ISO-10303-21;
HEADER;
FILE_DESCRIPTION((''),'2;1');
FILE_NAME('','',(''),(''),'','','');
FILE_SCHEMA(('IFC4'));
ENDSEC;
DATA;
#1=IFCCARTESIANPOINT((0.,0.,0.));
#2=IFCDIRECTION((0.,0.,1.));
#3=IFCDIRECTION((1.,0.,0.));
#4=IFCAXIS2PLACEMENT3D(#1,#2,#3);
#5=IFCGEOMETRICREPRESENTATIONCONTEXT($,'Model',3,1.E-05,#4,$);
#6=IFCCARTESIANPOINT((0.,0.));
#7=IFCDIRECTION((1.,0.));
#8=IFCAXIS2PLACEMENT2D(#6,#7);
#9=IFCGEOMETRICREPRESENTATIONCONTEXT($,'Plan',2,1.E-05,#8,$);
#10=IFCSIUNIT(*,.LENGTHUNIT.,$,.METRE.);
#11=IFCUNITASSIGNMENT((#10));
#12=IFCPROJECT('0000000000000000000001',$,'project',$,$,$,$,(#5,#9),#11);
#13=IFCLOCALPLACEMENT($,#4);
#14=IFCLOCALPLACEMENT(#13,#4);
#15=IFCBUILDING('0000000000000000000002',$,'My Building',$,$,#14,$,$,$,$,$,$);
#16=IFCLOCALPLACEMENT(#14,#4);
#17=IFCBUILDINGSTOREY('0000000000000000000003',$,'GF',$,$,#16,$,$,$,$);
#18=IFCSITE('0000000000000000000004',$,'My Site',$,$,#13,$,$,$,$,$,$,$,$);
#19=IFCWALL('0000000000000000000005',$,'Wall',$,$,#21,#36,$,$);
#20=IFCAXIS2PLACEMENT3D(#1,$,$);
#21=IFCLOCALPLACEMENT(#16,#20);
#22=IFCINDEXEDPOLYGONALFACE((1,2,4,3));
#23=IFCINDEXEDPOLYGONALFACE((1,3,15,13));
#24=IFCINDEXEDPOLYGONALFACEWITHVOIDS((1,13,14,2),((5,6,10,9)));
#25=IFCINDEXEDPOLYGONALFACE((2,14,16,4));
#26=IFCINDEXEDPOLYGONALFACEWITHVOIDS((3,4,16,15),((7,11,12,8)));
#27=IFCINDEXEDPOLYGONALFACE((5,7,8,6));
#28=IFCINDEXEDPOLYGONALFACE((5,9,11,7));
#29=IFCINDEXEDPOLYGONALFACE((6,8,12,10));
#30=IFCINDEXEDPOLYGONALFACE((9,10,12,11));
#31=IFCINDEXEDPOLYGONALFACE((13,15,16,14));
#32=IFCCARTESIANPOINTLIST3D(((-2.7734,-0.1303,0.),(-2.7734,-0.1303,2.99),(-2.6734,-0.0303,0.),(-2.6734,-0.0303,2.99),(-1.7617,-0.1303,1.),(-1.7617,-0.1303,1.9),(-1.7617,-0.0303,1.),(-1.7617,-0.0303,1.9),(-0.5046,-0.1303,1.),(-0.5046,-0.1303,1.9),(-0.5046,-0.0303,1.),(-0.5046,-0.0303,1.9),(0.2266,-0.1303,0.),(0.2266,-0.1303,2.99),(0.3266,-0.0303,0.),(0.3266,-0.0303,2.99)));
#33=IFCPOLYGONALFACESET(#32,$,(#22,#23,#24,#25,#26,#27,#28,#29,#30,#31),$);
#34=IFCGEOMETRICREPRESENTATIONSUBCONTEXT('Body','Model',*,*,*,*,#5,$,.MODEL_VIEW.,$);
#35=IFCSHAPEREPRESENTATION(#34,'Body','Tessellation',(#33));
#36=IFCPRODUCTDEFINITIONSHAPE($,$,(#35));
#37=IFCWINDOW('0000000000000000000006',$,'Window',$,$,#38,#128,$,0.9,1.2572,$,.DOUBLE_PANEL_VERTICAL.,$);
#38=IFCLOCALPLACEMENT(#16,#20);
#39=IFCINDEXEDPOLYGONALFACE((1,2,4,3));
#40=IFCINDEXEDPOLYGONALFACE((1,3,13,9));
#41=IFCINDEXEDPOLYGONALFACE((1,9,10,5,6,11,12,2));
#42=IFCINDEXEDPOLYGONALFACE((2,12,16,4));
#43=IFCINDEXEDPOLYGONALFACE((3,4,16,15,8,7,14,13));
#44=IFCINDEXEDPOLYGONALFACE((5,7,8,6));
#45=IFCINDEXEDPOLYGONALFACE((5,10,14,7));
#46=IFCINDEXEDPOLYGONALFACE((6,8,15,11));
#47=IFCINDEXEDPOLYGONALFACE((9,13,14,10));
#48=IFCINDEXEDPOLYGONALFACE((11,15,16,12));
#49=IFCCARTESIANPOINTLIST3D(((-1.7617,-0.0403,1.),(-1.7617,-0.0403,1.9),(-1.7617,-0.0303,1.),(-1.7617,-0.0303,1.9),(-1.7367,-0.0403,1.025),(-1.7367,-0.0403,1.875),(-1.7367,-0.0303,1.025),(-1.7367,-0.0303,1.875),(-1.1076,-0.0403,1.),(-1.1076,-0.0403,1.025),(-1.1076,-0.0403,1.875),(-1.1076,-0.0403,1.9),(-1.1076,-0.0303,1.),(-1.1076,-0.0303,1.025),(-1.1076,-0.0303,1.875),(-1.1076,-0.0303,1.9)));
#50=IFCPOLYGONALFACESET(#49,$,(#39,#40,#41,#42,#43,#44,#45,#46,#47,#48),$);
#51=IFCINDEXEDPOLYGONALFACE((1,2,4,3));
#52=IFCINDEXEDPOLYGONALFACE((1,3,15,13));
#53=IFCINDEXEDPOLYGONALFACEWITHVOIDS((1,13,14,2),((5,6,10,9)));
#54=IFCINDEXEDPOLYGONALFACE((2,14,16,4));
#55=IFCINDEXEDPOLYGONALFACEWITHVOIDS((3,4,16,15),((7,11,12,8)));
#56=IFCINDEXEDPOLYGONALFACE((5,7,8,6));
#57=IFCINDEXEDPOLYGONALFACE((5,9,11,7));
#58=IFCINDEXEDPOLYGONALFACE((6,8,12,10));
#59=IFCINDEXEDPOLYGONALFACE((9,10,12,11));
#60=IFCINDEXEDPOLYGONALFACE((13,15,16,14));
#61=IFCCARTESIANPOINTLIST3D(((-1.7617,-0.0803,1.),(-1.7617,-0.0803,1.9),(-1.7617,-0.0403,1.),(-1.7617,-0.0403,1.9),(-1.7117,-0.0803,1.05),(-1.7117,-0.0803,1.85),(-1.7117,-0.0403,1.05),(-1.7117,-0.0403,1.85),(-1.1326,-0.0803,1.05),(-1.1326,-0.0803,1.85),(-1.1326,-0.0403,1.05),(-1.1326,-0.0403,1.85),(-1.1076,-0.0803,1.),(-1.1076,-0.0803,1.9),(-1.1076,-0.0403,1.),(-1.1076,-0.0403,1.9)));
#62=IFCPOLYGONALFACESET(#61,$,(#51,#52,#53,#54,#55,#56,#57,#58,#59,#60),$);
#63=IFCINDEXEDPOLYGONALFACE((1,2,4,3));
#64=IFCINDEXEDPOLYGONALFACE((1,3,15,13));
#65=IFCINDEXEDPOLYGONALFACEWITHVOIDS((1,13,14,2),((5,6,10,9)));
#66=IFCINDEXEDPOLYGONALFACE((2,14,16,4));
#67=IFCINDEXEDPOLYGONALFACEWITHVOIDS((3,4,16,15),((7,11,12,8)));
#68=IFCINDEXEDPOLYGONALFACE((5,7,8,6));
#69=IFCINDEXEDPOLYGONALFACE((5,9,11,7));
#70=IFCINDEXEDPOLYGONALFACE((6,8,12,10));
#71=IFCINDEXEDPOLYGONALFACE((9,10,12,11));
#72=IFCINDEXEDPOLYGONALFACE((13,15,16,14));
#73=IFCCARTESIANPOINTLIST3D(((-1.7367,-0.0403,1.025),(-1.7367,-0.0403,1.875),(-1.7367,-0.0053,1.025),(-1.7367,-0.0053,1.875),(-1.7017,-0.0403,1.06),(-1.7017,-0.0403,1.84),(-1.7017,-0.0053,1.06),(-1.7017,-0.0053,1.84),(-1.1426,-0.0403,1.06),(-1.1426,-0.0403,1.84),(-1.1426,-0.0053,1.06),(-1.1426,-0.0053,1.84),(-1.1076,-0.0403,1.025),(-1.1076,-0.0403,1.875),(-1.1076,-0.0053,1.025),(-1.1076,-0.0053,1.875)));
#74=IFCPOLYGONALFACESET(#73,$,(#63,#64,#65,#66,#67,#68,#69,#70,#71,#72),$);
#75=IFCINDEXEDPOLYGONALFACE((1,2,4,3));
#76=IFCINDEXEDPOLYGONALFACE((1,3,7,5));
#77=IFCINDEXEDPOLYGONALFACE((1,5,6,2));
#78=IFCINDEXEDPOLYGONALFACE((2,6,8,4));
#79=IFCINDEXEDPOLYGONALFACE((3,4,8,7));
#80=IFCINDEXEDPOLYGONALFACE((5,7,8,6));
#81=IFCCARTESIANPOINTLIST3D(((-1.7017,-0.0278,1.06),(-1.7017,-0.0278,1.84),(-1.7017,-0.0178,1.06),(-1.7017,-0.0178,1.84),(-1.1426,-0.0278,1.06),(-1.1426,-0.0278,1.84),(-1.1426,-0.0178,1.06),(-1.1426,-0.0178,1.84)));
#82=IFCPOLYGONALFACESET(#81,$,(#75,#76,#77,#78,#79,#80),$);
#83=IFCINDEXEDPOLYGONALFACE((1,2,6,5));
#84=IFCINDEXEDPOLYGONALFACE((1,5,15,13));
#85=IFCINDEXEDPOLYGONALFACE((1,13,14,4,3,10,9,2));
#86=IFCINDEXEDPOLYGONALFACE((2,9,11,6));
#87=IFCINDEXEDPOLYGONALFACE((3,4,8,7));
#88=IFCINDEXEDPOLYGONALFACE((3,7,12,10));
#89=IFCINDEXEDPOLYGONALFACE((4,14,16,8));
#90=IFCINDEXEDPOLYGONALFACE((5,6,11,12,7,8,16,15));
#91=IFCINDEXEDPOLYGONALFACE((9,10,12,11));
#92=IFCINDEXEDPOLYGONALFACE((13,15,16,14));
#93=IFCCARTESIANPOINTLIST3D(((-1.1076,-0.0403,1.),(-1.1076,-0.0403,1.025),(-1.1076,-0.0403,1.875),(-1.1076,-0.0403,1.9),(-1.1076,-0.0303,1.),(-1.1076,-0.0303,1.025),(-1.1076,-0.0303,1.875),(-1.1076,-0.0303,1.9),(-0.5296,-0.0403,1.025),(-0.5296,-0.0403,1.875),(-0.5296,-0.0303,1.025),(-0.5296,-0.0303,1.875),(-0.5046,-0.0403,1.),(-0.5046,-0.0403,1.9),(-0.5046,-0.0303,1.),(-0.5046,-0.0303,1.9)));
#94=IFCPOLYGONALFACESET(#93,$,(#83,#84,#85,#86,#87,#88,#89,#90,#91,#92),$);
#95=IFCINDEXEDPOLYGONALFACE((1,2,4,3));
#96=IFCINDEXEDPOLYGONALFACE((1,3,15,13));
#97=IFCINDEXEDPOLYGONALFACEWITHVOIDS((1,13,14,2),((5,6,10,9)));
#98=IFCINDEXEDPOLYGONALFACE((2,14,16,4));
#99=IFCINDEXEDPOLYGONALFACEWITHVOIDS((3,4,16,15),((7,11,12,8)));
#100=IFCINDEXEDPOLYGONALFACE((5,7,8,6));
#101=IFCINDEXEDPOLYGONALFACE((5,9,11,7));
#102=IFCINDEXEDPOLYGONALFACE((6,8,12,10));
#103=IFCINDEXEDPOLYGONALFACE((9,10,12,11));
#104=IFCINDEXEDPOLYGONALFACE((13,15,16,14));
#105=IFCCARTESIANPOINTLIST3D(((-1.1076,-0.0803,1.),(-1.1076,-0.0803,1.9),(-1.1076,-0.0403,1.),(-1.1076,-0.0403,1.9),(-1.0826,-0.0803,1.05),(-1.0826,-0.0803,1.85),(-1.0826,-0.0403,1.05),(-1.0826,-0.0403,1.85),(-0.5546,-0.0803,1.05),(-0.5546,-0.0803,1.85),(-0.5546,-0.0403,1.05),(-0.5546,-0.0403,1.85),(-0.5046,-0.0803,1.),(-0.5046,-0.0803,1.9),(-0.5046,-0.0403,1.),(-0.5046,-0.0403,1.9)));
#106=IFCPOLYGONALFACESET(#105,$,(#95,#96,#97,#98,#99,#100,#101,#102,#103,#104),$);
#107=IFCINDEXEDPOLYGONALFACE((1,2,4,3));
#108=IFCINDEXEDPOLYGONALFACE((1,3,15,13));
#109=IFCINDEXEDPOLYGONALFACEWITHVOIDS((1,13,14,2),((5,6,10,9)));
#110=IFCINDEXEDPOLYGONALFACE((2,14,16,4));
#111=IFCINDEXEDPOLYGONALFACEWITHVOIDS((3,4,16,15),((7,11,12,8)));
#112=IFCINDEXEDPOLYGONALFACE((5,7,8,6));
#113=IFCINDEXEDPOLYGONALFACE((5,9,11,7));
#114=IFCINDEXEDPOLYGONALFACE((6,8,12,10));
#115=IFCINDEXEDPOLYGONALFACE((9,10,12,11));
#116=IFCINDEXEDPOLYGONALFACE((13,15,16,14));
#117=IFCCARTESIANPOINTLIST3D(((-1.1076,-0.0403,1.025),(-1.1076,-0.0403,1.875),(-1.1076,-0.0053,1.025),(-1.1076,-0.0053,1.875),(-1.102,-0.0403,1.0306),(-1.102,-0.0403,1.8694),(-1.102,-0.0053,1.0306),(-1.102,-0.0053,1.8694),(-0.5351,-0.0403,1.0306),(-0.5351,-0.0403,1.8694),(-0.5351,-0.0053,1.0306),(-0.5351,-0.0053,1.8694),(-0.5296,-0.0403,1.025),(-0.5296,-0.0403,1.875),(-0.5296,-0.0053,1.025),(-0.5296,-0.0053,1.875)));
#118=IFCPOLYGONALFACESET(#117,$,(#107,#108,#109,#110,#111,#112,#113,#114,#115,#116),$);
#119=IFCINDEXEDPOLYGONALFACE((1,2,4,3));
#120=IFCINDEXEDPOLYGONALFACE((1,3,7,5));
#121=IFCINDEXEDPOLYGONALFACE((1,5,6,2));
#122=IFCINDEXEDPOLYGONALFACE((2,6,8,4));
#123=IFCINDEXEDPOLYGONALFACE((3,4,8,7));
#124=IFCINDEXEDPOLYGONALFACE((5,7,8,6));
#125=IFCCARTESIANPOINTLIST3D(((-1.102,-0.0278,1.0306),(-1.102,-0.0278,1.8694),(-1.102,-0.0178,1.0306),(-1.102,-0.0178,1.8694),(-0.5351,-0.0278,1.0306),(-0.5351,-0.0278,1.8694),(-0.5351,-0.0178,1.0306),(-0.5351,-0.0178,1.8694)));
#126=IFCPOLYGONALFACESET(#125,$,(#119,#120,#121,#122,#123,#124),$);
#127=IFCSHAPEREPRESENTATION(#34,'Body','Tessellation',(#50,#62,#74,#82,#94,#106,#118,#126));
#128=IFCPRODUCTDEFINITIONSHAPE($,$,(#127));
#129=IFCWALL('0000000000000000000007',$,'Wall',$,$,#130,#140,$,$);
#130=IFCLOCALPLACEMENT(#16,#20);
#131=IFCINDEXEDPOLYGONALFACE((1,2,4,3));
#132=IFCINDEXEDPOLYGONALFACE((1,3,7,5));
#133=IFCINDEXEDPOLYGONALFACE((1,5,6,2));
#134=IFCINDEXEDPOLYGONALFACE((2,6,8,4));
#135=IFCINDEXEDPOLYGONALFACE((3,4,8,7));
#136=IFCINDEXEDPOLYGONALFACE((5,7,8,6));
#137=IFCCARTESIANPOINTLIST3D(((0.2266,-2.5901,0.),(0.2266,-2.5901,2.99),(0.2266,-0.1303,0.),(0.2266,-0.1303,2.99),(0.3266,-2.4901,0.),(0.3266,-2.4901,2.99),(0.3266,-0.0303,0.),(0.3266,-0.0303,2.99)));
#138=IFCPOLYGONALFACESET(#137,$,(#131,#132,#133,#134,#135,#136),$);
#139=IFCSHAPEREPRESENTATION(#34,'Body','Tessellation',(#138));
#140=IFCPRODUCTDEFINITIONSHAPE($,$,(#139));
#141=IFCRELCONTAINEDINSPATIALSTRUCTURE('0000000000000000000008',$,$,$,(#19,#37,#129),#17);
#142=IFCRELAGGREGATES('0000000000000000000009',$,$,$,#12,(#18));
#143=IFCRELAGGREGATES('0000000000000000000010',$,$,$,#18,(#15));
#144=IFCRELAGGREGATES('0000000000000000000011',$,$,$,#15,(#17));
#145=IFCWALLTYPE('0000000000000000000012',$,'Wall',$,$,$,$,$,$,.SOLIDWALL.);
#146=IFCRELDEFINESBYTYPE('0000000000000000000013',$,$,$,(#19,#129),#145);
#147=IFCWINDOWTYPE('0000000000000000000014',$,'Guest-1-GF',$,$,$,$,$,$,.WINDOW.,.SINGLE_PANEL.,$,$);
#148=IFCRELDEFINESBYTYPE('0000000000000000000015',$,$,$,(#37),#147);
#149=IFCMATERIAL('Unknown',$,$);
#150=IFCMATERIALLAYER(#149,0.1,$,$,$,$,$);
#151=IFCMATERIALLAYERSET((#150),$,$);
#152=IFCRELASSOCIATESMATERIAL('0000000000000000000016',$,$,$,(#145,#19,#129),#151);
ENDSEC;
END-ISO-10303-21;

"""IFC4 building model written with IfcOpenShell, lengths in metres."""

from ifc_helpers import new_model, entity, si_unit, frame, origin_with_axes, origin_2d_with_axis, place, context, subcontext, project, spatial, line, indexed_curve, outline, extrude, shape, source, transform, mapped, material, layer, layer_set, layer_usage, type_object, type_shapes, element, fill, save


model = new_model("IFC4")

# Units and contexts
model_context = context("Model", 3, precision=1e-05, world=origin_with_axes())
plan_context = context("Plan", 2, precision=1e-05, world=origin_2d_with_axis())
body_context_1 = subcontext(model_context, "Body", "Model", "MODEL_VIEW")
body_context_2 = subcontext(plan_context, "Body", "Plan", "PLAN_VIEW")
ifc_project = project(units=[si_unit("LENGTHUNIT", "METRE")], contexts=[model_context, plan_context])

# Site, building, storey
site_placement = place(None, origin_with_axes())
site = spatial("IfcSite", under=ifc_project, at=site_placement, Name="My Site")
building_placement = place(site_placement, origin_with_axes())
building = spatial("IfcBuilding", under=site, at=building_placement, Name="My Building")
storey_placement = place(building_placement, origin_with_axes())
storey = spatial("IfcBuildingStorey", under=building, at=storey_placement, Name="GF")

# Shared definitions
ifc_material = material(Name="Unknown")

# Shared definitions
ifc_layer_1 = layer(ifc_material, 0.1)
ifc_layer_set_1 = layer_set([ifc_layer_1])
wall_type = type_object("IfcWallType", Name="Wall", PredefinedType="SOLIDWALL", material=ifc_layer_set_1)

# Wall, opening, window
ifc_layer_usage_1 = layer_usage(ifc_layer_set_1, "AXIS2", "POSITIVE", 0.0)
wall_1_placement = place(storey_placement, frame((-2.7734, -0.1303, 0.0), z_axis=(0.0, 0.0, 1.0), x_axis=(1.0, 0.0, 0.0)))
wall_1 = element("IfcWall", 1, at=wall_1_placement, inside=storey, type_object=wall_type, material=ifc_layer_usage_1, Name="Wall", context=body_context_1, shape_type="SweptSolid", body=[
    extrude(outline(indexed_curve([(0.0, 0.0), (0.1, 0.1), (3.1, 0.1), (3.0, 0.0)], segments=[line(1, 2, 3, 4, 1)])), origin_with_axes(), (0.0, 0.0, 1.0), 2.99),
])
shared_shape_1 = source(origin_with_axes(), body_context_1, "Body", "SweptSolid", [
    extrude(outline(indexed_curve([(0.0, 0.0), (1.2572, 0.0), (1.2572, 0.9), (0.0, 0.9)], segments=[line(1, 2, 3, 4, 1)])), frame((0.0, -0.6, 0.0), z_axis=(0.0, -1.0, 0.0), x_axis=(1.0, 0.0, 0.0)), (0.0, 0.0, -1.0), 1.2),
])
opening_1_placement = place(wall_1_placement, frame((1.0116, 0.0, 1.0), z_axis=(0.0, 0.0, 1.0), x_axis=(1.0, 0.0, 0.0)))
opening_1 = element("IfcOpeningElement", 2, at=opening_1_placement, cuts=wall_1, PredefinedType="OPENING", context=body_context_1, shape_type="MappedRepresentation", body=[
    mapped(shared_shape_1, transform((0.0, 0.0, 0.0), x_axis=(1.0, 0.0, 0.0), y_axis=(0.0, 1.0, 0.0), z_axis=(0.0, 0.0, 1.0), scale=1.0)),
])
window_type_1 = type_object("IfcWindowType", Name="Guest-1-GF", PartitioningType="SINGLE_PANEL", PredefinedType="WINDOW")
shared_shape_2 = source(origin_with_axes(), body_context_1, "Body", "SweptSolid", [
    extrude(outline(indexed_curve([(0.6541, 0.0), (0.0, 0.0), (0.0, 0.9), (0.6541, 0.9), (0.6541, 0.875), (0.025, 0.875), (0.025, 0.025), (0.6541, 0.025)], segments=[line(1, 2, 3, 4, 5, 6, 7, 8, 1)])), frame((0.0, 0.09, 0.0), z_axis=(0.0, -1.0, 0.0), x_axis=(1.0, 0.0, 0.0)), (0.0, 0.0, -1.0), 0.01),
    extrude(outline(indexed_curve([(0.0, 0.0), (0.6541, 0.0), (0.6541, 0.9), (0.0, 0.9)], segments=[line(1, 2, 3, 4, 1)]), holes=[indexed_curve([(0.05, 0.05), (0.6291, 0.05), (0.6291, 0.85), (0.05, 0.85)], segments=[line(1, 2, 3, 4, 1)])]), frame((0.0, 0.05, 0.0), z_axis=(0.0, -1.0, 0.0), x_axis=(1.0, 0.0, 0.0)), (0.0, 0.0, -1.0), 0.04),
    extrude(outline(indexed_curve([(0.0, 0.0), (0.6291, 0.0), (0.6291, 0.85), (0.0, 0.85)], segments=[line(1, 2, 3, 4, 1)]), holes=[indexed_curve([(0.035, 0.035), (0.5941, 0.035), (0.5941, 0.815), (0.035, 0.815)], segments=[line(1, 2, 3, 4, 1)])]), frame((0.025, 0.09, 0.025), z_axis=(0.0, -1.0, 0.0), x_axis=(1.0, 0.0, 0.0)), (0.0, 0.0, -1.0), 0.035),
    extrude(outline(indexed_curve([(0.035, 0.035), (0.5941, 0.035), (0.5941, 0.815), (0.035, 0.815)], segments=[line(1, 2, 3, 4, 1)])), frame((0.025, 0.1025, 0.025), z_axis=(0.0, -1.0, 0.0), x_axis=(1.0, 0.0, 0.0)), (0.0, 0.0, -1.0), 0.01),
    extrude(outline(indexed_curve([(0.0, 0.9), (0.603, 0.9), (0.603, 0.0), (0.0, 0.0), (0.0, 0.025), (0.578, 0.025), (0.578, 0.875), (0.0, 0.875)], segments=[line(1, 2, 3, 4, 5, 6, 7, 8, 1)])), frame((0.6541, 0.09, 0.0), z_axis=(0.0, -1.0, 0.0), x_axis=(1.0, 0.0, 0.0)), (0.0, 0.0, -1.0), 0.01),
    extrude(outline(indexed_curve([(0.0, 0.0), (0.603, 0.0), (0.603, 0.9), (0.0, 0.9)], segments=[line(1, 2, 3, 4, 1)]), holes=[indexed_curve([(0.025, 0.05), (0.553, 0.05), (0.553, 0.85), (0.025, 0.85)], segments=[line(1, 2, 3, 4, 1)])]), frame((0.6541, 0.05, 0.0), z_axis=(0.0, -1.0, 0.0), x_axis=(1.0, 0.0, 0.0)), (0.0, 0.0, -1.0), 0.04),
    extrude(outline(indexed_curve([(0.0, 0.0), (0.578, 0.0), (0.578, 0.85), (0.0, 0.85)], segments=[line(1, 2, 3, 4, 1)]), holes=[indexed_curve([(0.0056, 0.0056), (0.5725, 0.0056), (0.5725, 0.8444), (0.0056, 0.8444)], segments=[line(1, 2, 3, 4, 1)])]), frame((0.6541, 0.09, 0.025), z_axis=(0.0, -1.0, 0.0), x_axis=(1.0, 0.0, 0.0)), (0.0, 0.0, -1.0), 0.035),
    extrude(outline(indexed_curve([(0.0056, 0.0056), (0.5725, 0.0056), (0.5725, 0.8444), (0.0056, 0.8444)], segments=[line(1, 2, 3, 4, 1)])), frame((0.6541, 0.1025, 0.025), z_axis=(0.0, -1.0, 0.0), x_axis=(1.0, 0.0, 0.0)), (0.0, 0.0, -1.0), 0.01),
])
shared_shape_3 = source(origin_with_axes(), body_context_2, "Body", "Curve2D", [
    entity("IfcIndexedPolyCurve", entity("IfcCartesianPointList2D", [[0.05, 0.05], [0.6291, 0.05]])),
    entity("IfcIndexedPolyCurve", entity("IfcCartesianPointList2D", [[0.0, 0.1], [0.025, 0.1], [0.025, 0.09], [0.05, 0.09], [0.05, 0.05], [0.0, 0.05]]), [entity("IfcLineIndex", [1, 2, 3, 4, 5, 6, 1])]),
    entity("IfcIndexedPolyCurve", entity("IfcCartesianPointList2D", [[0.6541, 0.1], [0.6541, 0.1], [0.6541, 0.09], [0.6291, 0.09], [0.6291, 0.05], [0.6541, 0.05]])),
    entity("IfcIndexedPolyCurve", entity("IfcCartesianPointList2D", [[0.025, 0.09], [0.06, 0.09], [0.06, 0.125], [0.025, 0.125]]), [entity("IfcLineIndex", [1, 2, 3, 4, 1])]),
    entity("IfcIndexedPolyCurve", entity("IfcCartesianPointList2D", [[0.6541, 0.09], [0.6191, 0.09], [0.6191, 0.125], [0.6541, 0.125]]), [entity("IfcLineIndex", [1, 2, 3, 4, 1])]),
    entity("IfcIndexedPolyCurve", entity("IfcCartesianPointList2D", [[0.06, 0.09], [0.6191, 0.09]])),
    entity("IfcIndexedPolyCurve", entity("IfcCartesianPointList2D", [[0.06, 0.125], [0.6191, 0.125]])),
    entity("IfcIndexedPolyCurve", entity("IfcCartesianPointList2D", [[0.06, 0.1075], [0.6191, 0.1075]])),
    entity("IfcIndexedPolyCurve", entity("IfcCartesianPointList2D", [[0.6791, 0.05], [1.2072, 0.05]])),
    entity("IfcIndexedPolyCurve", entity("IfcCartesianPointList2D", [[0.6541, 0.1], [0.6541, 0.1], [0.6541, 0.09], [0.6791, 0.09], [0.6791, 0.05], [0.6541, 0.05]])),
    entity("IfcIndexedPolyCurve", entity("IfcCartesianPointList2D", [[1.2572, 0.1], [1.2322, 0.1], [1.2322, 0.09], [1.2072, 0.09], [1.2072, 0.05], [1.2572, 0.05]]), [entity("IfcLineIndex", [1, 2, 3, 4, 5, 6, 1])]),
    entity("IfcIndexedPolyCurve", entity("IfcCartesianPointList2D", [[0.6541, 0.09], [0.6597, 0.09], [0.6597, 0.125], [0.6541, 0.125]]), [entity("IfcLineIndex", [1, 2, 3, 4, 1])]),
    entity("IfcIndexedPolyCurve", entity("IfcCartesianPointList2D", [[1.2322, 0.09], [1.2266, 0.09], [1.2266, 0.125], [1.2322, 0.125]]), [entity("IfcLineIndex", [1, 2, 3, 4, 1])]),
    entity("IfcIndexedPolyCurve", entity("IfcCartesianPointList2D", [[0.6597, 0.09], [1.2266, 0.09]])),
    entity("IfcIndexedPolyCurve", entity("IfcCartesianPointList2D", [[0.6597, 0.125], [1.2266, 0.125]])),
    entity("IfcIndexedPolyCurve", entity("IfcCartesianPointList2D", [[0.6597, 0.1075], [1.2266, 0.1075]])),
])
type_shapes(window_type_1, [shared_shape_2, shared_shape_3])
window_1_placement = place(opening_1_placement, frame((0.0, 0.0, 0.0), z_axis=(0.0, 0.0, 1.0), x_axis=(1.0, 0.0, 0.0)))
window_1 = element("IfcWindow", 3, at=window_1_placement, inside=storey, type_object=window_type_1, Name="Window", OverallHeight=0.9, OverallWidth=1.2572, PartitioningType="DOUBLE_PANEL_VERTICAL", shapes=[
    shape(body_context_1, "Body", "MappedRepresentation", [mapped(shared_shape_2, transform((0.0, 0.0, 0.0), x_axis=(1.0, 0.0, 0.0), y_axis=(0.0, 1.0, 0.0), z_axis=(0.0, 0.0, 1.0), scale=1.0))]),
    shape(body_context_2, "Body", "MappedRepresentation", [mapped(shared_shape_3, transform((0.0, 0.0, 0.0), x_axis=(1.0, 0.0, 0.0), y_axis=(0.0, 1.0, 0.0), z_axis=(0.0, 0.0, 1.0), scale=1.0))]),
])
fill(opening_1, window_1)

# Wall
ifc_layer_usage_2 = layer_usage(ifc_layer_set_1, "AXIS2", "POSITIVE", 0.0)
wall_2_placement = place(storey_placement, frame((0.2266, -0.1303, 0.0), z_axis=(0.0, 0.0, 1.0), x_axis=(0.0, -1.0, 0.0)))
element("IfcWall", 4, at=wall_2_placement, inside=storey, type_object=wall_type, material=ifc_layer_usage_2, Name="Wall", context=body_context_1, shape_type="SweptSolid", body=[
    extrude(outline(indexed_curve([(0.0, 0.0), (-0.1, 0.1), (2.3598, 0.1), (2.4598, 0.0)], segments=[line(1, 2, 3, 4, 1)])), origin_with_axes(), (0.0, 0.0, 1.0), 2.99),
])

save(model, "model.ifc")
